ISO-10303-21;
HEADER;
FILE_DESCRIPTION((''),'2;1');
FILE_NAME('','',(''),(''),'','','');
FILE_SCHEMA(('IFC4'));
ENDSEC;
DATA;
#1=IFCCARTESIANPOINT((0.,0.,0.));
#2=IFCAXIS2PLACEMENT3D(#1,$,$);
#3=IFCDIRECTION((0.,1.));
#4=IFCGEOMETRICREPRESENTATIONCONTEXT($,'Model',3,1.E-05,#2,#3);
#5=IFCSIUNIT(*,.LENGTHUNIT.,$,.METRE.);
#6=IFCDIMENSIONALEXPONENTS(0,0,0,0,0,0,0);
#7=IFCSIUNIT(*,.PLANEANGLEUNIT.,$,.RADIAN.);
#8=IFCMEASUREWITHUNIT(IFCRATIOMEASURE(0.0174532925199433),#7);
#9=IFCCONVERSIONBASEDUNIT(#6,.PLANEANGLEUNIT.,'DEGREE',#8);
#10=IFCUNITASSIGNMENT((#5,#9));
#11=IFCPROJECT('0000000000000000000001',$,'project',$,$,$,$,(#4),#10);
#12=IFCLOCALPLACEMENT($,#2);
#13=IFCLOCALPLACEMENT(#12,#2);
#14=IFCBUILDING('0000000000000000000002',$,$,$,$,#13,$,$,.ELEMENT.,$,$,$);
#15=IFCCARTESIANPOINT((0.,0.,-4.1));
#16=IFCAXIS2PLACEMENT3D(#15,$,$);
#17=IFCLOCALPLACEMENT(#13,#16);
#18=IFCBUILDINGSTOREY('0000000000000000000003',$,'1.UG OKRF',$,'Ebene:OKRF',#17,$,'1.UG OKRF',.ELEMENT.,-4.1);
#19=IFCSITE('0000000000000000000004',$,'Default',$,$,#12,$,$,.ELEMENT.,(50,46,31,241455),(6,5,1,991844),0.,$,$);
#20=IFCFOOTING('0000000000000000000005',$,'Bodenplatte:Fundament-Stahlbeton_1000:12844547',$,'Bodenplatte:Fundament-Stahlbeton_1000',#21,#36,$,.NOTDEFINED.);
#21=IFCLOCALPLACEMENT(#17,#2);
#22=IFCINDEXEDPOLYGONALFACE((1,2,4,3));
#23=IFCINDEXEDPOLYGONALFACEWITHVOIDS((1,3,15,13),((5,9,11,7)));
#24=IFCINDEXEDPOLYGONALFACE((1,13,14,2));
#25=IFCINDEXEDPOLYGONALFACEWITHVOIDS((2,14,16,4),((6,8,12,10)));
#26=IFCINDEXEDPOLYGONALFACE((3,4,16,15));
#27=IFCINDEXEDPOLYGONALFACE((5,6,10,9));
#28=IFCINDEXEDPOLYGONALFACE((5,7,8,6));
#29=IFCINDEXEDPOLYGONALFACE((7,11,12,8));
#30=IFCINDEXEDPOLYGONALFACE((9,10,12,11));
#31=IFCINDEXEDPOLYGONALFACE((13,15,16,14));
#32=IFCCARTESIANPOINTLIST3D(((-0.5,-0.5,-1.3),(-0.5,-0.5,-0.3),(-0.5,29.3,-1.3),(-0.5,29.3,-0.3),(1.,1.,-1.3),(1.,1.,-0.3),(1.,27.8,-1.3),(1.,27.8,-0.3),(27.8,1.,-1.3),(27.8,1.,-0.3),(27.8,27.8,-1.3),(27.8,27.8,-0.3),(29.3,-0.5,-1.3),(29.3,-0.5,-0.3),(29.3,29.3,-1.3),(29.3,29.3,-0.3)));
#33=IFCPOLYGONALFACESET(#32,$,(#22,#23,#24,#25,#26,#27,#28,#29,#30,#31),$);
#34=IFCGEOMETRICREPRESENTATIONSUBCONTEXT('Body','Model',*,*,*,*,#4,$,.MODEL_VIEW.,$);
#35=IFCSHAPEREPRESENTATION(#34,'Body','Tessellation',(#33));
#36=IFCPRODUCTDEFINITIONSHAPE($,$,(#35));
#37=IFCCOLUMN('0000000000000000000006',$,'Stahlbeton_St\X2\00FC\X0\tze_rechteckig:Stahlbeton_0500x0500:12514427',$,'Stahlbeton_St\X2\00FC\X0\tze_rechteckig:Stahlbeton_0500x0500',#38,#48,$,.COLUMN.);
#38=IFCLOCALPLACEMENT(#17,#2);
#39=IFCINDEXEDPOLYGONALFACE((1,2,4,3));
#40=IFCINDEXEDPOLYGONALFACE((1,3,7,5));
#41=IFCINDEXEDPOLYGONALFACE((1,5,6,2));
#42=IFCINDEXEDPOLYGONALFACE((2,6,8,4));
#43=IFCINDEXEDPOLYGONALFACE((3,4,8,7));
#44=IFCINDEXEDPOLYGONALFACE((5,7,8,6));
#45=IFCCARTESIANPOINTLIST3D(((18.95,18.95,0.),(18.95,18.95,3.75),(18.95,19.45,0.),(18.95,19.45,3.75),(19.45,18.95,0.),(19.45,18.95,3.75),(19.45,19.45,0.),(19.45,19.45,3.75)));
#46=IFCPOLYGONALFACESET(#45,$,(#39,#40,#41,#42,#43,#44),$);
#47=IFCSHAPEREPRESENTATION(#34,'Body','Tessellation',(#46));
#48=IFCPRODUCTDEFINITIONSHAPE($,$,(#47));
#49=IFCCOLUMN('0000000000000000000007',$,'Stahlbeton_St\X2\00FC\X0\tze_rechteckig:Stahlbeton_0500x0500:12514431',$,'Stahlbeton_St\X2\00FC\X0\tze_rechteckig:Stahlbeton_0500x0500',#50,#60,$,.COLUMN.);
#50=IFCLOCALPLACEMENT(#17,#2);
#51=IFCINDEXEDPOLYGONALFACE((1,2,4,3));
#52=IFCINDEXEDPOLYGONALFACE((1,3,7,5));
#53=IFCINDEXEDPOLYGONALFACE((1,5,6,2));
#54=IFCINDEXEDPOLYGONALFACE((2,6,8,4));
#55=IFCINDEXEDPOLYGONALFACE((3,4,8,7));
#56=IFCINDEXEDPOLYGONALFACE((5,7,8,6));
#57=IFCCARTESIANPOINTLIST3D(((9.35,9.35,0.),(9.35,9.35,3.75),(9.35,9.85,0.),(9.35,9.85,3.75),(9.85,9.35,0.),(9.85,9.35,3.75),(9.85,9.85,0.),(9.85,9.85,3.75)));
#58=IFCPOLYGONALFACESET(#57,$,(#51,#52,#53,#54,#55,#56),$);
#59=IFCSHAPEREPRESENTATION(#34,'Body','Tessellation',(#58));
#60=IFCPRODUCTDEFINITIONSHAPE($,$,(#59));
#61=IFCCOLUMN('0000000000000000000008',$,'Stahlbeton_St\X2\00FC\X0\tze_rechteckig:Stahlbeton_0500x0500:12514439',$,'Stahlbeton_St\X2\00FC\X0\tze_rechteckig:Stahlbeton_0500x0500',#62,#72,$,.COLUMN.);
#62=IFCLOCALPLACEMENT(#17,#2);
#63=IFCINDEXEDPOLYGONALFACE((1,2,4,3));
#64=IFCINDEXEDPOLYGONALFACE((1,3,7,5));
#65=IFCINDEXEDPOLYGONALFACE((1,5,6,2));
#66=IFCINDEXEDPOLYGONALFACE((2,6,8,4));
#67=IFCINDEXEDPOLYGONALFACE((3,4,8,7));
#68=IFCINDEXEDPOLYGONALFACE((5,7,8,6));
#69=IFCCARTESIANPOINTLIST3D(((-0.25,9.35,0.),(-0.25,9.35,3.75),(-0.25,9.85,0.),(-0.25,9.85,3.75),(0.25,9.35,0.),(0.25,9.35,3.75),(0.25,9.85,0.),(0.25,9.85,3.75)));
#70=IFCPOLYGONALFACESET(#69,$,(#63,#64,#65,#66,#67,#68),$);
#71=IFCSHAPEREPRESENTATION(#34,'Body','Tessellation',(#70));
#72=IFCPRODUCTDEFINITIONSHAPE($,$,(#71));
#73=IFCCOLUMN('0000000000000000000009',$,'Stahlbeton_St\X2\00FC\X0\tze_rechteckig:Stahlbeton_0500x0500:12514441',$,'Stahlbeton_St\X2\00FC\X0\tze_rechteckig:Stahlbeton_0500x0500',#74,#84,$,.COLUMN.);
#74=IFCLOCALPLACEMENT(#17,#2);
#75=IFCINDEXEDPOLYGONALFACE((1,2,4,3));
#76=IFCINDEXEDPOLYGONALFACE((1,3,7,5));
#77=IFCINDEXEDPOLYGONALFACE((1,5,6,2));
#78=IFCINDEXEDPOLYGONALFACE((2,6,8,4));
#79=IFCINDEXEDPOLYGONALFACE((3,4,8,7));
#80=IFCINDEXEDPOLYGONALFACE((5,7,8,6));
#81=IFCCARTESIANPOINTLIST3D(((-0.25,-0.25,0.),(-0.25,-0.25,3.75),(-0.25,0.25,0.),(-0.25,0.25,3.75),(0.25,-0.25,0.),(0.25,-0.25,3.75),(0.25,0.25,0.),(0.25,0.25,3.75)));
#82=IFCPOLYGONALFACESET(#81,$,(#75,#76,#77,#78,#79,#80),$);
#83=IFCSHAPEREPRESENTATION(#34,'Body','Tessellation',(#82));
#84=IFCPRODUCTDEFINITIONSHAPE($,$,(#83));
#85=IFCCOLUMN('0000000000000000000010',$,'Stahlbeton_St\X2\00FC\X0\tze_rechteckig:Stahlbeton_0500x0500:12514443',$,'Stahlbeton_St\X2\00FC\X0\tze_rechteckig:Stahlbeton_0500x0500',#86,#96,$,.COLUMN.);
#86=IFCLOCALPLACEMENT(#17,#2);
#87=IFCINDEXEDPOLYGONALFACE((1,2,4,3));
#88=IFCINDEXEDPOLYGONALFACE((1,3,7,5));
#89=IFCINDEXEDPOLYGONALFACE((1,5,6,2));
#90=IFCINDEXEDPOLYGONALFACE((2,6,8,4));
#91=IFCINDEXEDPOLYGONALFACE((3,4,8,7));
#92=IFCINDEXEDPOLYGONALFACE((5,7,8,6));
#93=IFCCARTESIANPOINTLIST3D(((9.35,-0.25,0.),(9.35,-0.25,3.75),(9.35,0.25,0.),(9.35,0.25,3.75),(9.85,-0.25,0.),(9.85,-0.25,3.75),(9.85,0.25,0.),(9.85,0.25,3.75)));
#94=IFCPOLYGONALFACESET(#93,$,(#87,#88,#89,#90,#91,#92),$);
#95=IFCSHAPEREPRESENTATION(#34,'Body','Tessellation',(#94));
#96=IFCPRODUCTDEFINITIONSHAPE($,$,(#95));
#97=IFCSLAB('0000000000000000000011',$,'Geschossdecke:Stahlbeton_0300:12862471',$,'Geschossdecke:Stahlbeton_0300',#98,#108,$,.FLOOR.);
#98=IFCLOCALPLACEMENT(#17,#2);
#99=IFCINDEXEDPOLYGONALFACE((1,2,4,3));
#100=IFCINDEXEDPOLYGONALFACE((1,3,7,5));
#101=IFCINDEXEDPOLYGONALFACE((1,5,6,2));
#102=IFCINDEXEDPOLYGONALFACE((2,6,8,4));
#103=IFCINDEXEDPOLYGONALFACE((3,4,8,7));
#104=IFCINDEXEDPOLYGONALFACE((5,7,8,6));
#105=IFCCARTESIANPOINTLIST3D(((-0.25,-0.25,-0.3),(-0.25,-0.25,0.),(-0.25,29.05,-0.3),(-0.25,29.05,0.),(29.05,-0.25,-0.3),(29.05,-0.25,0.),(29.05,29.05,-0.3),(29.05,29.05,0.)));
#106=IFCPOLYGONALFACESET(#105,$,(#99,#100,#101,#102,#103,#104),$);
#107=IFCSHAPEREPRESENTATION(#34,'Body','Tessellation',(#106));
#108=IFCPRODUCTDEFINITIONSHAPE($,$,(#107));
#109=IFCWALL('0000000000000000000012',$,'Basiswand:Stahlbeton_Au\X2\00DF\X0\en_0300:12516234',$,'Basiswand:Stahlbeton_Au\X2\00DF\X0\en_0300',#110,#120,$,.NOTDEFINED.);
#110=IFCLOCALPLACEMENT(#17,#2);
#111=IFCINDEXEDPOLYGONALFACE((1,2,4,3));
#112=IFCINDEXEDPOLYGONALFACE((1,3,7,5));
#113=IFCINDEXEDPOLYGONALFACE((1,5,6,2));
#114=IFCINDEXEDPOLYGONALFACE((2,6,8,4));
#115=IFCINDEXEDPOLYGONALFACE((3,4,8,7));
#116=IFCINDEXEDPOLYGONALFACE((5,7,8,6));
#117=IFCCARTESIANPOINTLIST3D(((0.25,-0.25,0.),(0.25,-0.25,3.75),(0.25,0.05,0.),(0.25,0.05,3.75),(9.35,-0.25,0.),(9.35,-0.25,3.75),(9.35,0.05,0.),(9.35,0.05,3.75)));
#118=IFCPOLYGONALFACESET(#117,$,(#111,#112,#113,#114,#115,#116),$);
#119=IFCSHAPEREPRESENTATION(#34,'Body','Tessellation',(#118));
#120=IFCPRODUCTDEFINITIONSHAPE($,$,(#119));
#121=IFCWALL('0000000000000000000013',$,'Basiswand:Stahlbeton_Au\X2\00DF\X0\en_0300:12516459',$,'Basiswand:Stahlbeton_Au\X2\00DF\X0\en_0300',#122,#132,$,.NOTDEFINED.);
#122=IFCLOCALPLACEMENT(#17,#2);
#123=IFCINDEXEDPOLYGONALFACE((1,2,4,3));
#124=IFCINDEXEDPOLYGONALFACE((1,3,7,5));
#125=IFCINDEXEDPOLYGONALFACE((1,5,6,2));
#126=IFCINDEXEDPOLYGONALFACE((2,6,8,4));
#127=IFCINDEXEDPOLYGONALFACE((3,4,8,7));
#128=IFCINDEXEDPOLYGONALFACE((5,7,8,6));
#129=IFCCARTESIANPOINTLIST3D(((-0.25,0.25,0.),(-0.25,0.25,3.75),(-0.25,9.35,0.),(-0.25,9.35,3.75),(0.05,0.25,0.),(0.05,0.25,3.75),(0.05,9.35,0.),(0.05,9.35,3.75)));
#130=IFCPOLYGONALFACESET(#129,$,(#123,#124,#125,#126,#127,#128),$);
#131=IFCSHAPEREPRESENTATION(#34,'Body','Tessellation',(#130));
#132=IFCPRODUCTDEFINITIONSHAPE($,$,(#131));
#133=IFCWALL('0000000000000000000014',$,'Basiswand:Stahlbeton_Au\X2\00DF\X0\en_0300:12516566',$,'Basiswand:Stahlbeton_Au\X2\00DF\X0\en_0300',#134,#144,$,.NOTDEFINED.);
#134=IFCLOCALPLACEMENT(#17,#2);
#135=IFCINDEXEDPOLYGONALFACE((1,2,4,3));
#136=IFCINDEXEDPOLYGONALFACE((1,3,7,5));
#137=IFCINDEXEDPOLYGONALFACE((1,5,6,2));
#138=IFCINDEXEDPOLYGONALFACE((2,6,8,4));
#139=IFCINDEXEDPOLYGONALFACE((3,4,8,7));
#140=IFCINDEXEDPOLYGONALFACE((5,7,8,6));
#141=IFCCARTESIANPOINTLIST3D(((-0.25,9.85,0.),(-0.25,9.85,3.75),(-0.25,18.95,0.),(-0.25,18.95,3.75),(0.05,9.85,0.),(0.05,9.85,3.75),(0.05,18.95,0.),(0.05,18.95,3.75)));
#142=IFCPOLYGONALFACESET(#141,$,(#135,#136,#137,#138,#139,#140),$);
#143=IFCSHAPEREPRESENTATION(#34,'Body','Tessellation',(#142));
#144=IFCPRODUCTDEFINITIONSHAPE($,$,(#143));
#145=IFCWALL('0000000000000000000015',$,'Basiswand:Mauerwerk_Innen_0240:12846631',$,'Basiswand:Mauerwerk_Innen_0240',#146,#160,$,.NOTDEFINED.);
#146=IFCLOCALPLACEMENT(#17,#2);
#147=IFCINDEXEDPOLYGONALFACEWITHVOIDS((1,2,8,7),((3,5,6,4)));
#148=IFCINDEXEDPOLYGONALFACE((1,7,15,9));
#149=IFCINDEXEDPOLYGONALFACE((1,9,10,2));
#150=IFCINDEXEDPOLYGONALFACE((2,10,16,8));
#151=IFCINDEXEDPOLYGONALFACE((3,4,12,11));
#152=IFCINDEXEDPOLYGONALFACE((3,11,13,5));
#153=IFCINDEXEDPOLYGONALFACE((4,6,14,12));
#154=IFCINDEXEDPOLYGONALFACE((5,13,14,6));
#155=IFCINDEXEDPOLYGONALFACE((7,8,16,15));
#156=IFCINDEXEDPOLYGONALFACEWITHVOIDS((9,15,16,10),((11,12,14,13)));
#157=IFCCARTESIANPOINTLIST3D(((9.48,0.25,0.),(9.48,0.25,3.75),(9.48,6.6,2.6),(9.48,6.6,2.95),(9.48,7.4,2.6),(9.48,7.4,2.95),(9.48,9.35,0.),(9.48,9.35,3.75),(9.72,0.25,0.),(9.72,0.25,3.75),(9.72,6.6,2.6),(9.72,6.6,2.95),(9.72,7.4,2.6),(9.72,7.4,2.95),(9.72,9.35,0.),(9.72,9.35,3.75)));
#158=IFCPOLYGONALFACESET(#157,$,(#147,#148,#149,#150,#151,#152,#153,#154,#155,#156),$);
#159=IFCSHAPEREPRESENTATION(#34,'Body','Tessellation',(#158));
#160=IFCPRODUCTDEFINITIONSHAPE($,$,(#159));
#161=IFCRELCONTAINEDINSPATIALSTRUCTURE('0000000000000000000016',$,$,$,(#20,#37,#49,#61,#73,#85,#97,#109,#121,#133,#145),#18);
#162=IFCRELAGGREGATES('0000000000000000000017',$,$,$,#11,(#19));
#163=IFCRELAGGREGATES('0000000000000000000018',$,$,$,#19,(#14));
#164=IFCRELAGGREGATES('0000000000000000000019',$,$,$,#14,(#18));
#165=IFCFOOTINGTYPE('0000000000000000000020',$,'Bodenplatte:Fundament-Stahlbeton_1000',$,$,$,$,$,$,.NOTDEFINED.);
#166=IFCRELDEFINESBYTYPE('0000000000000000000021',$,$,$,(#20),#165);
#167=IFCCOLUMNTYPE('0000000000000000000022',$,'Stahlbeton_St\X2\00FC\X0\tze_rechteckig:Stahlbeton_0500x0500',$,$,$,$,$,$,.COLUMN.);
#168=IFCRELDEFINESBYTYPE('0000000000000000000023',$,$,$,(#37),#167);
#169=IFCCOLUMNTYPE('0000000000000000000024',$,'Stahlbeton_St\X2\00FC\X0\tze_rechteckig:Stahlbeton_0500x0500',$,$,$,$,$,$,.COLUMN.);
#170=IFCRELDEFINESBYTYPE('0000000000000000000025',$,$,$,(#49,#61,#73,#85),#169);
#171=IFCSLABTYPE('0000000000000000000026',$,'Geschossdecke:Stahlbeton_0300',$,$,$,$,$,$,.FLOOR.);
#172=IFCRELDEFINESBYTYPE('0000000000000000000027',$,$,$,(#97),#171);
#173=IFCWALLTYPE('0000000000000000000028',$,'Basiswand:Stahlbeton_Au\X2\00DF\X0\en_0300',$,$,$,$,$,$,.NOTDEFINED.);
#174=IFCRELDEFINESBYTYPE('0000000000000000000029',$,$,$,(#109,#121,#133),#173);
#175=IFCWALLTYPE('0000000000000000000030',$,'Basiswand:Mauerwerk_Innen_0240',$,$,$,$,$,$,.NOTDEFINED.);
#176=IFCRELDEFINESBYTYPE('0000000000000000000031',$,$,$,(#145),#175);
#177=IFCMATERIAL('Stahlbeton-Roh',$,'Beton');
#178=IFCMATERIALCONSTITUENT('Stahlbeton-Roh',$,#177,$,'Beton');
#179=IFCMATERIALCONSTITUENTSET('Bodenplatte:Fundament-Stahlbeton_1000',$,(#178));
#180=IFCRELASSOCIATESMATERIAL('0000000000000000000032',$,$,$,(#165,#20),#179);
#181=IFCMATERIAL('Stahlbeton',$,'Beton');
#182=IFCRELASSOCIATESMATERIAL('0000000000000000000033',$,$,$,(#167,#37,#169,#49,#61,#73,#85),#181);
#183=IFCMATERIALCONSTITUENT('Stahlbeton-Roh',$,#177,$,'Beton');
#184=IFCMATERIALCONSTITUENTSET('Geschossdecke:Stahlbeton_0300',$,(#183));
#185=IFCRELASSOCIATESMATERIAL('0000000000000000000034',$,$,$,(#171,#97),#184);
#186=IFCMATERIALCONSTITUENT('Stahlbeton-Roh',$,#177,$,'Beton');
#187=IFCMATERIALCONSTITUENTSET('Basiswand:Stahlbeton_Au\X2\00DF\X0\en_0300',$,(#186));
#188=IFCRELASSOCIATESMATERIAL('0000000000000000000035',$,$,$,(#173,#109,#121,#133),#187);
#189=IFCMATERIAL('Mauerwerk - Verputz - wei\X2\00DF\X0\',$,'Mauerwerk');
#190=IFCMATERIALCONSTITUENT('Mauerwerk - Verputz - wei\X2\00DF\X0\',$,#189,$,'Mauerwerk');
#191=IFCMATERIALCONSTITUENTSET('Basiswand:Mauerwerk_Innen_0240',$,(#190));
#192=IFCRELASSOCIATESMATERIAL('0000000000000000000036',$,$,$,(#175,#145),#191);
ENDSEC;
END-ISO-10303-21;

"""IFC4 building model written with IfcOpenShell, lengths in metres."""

from ifc_helpers import new_model, entity, si_unit, converted_unit, direction, frame, origin, place, context, subcontext, project, spatial, polyline, indexed_curve, outline, extrude, source, transform, mapped, material, constituent, constituent_set, type_object, type_shapes, element, save


model = new_model("IFC4")

# Units and contexts
model_context = context("Model", 3, precision=1e-05, world=origin(), true_north=direction((0.0, 1.0)))
body_context = subcontext(model_context, "Body", "Model", "MODEL_VIEW")
ifc_project = project(units=[si_unit("LENGTHUNIT", "METRE"), converted_unit("PLANEANGLEUNIT", "DEGREE", entity("IfcRatioMeasure", 0.0174532925199433), si_unit("PLANEANGLEUNIT", "RADIAN"), dimensions=[0, 0, 0, 0, 0, 0, 0])], contexts=[model_context])

# Site, building, storey
site_placement = place(None, origin())
site = spatial("IfcSite", under=ifc_project, at=site_placement, Name="Default", CompositionType="ELEMENT", RefLatitude=(50, 46, 31, 241455), RefLongitude=(6, 5, 1, 991844), RefElevation=0.0)
building_placement = place(site_placement, origin())
building = spatial("IfcBuilding", under=site, at=building_placement, CompositionType="ELEMENT")
storey_placement = place(building_placement, frame((0.0, 0.0, -4.1)))
storey = spatial("IfcBuildingStorey", under=building, at=storey_placement, Name="1.UG OKRF", ObjectType="Ebene:OKRF", LongName="1.UG OKRF", CompositionType="ELEMENT", Elevation=-4.1)

# Footing
ifc_material_1 = material(Name="Stahlbeton-Roh", Category="Beton")
ifc_constituent_1 = constituent(ifc_material_1, Name="Stahlbeton-Roh", Category="Beton")
ifc_constituent_set_1 = constituent_set(constituents=[ifc_constituent_1], Name="Bodenplatte:Fundament-Stahlbeton_1000")
footing_type = type_object("IfcFootingType", Name="Bodenplatte:Fundament-Stahlbeton_1000", PredefinedType="NOTDEFINED", material=ifc_constituent_set_1)
footing_placement = place(storey_placement, origin())
element("IfcFooting", 1, at=footing_placement, inside=storey, type_object=footing_type, material=ifc_constituent_set_1, Name="Bodenplatte:Fundament-Stahlbeton_1000:12844547", ObjectType="Bodenplatte:Fundament-Stahlbeton_1000", PredefinedType="NOTDEFINED", context=body_context, shape_type="SweptSolid", body=[
    extrude(outline(polyline([(-14.9, -14.9), (14.9, -14.9), (14.9, 14.9), (-14.9, 14.9), (-14.9, -14.9)]), holes=[polyline([(-13.4, -13.4), (13.4, -13.4), (13.4, 13.4), (-13.4, 13.4), (-13.4, -13.4)])]), frame((14.4, 14.4, -1.3), z_axis=(0.0, 0.0, -1.0), x_axis=(0.0, 1.0, 0.0)), (0.0, 0.0, -1.0), 1.0),
])

# Columns
ifc_material_2 = material(Name="Stahlbeton", Category="Beton")
column_type_1 = type_object("IfcColumnType", Name="Stahlbeton_Stütze_rechteckig:Stahlbeton_0500x0500", PredefinedType="COLUMN", material=ifc_material_2)
shared_shape_1 = source(origin(), body_context, "Body", "SweptSolid", [
    extrude(outline(indexed_curve([(-0.25, -0.25), (0.25, -0.25), (0.25, 0.25), (-0.25, 0.25), (-0.25, -0.25)], self_intersect=False)), frame((19.2, 19.2, -4.1), z_axis=(0.0, 0.0, 1.0), x_axis=(0.0, -1.0, 0.0)), (0.0, 0.0, 1.0), 3.75),
])
type_shapes(column_type_1, [shared_shape_1])
column_placement = place(storey_placement, frame((0.0, 0.0, 4.1)))
element("IfcColumn", 2, at=column_placement, inside=storey, type_object=column_type_1, material=ifc_material_2, Name="Stahlbeton_Stütze_rechteckig:Stahlbeton_0500x0500:12514427", ObjectType="Stahlbeton_Stütze_rechteckig:Stahlbeton_0500x0500", PredefinedType="COLUMN", context=body_context, shape_type="MappedRepresentation", body=[
    mapped(shared_shape_1, transform((0.0, 0.0, 0.0), scale=1.0)),
])
column_type_2 = type_object("IfcColumnType", Name="Stahlbeton_Stütze_rechteckig:Stahlbeton_0500x0500", PredefinedType="COLUMN", material=ifc_material_2)
shared_shape_2 = source(origin(), body_context, "Body", "SweptSolid", [
    extrude(outline(indexed_curve([(-0.25, -0.25), (0.25, -0.25), (0.25, 0.25), (-0.25, 0.25), (-0.25, -0.25)], self_intersect=False)), frame((0.0, 0.0, -4.1), z_axis=(0.0, 0.0, 1.0), x_axis=(0.0, -1.0, 0.0)), (0.0, 0.0, 1.0), 3.75),
])
type_shapes(column_type_2, [shared_shape_2])
for number, where, name in (
    (3, (9.6, 9.6, 4.1), "Stahlbeton_Stütze_rechteckig:Stahlbeton_0500x0500:12514431"),
    (4, (0.0, 9.6, 4.1), "Stahlbeton_Stütze_rechteckig:Stahlbeton_0500x0500:12514439"),
    (5, (0.0, 0.0, 4.1), "Stahlbeton_Stütze_rechteckig:Stahlbeton_0500x0500:12514441"),
    (6, (9.6, 0.0, 4.1), "Stahlbeton_Stütze_rechteckig:Stahlbeton_0500x0500:12514443"),
):
    element("IfcColumn", number, at=place(storey_placement, frame(where)), inside=storey, type_object=column_type_2, material=ifc_material_2, Name=name, ObjectType="Stahlbeton_Stütze_rechteckig:Stahlbeton_0500x0500", PredefinedType="COLUMN", context=body_context, shape_type="MappedRepresentation", body=[
        mapped(shared_shape_2, transform((0.0, 0.0, 0.0), scale=1.0)),
    ])

# Slab
ifc_constituent_2 = constituent(ifc_material_1, Name="Stahlbeton-Roh", Category="Beton")
ifc_constituent_set_2 = constituent_set(constituents=[ifc_constituent_2], Name="Geschossdecke:Stahlbeton_0300")
slab_type = type_object("IfcSlabType", Name="Geschossdecke:Stahlbeton_0300", PredefinedType="FLOOR", material=ifc_constituent_set_2)
slab_placement = place(storey_placement, origin())
element("IfcSlab", 7, at=slab_placement, inside=storey, type_object=slab_type, material=ifc_constituent_set_2, Name="Geschossdecke:Stahlbeton_0300:12862471", ObjectType="Geschossdecke:Stahlbeton_0300", PredefinedType="FLOOR", context=body_context, shape_type="SweptSolid", body=[
    extrude(outline(polyline([(-14.65, -14.65), (14.65, -14.65), (14.65, 14.65), (-14.65, 14.65), (-14.65, -14.65)])), frame((14.4, 14.4, -0.3), z_axis=(0.0, 0.0, -1.0), x_axis=(0.0, -1.0, 0.0)), (0.0, 0.0, -1.0), 0.3),
])

# Walls
ifc_constituent_3 = constituent(ifc_material_1, Name="Stahlbeton-Roh", Category="Beton")
ifc_constituent_set_3 = constituent_set(constituents=[ifc_constituent_3], Name="Basiswand:Stahlbeton_Außen_0300")
wall_type_1 = type_object("IfcWallType", Name="Basiswand:Stahlbeton_Außen_0300", PredefinedType="NOTDEFINED", material=ifc_constituent_set_3)
wall_1_placement = place(storey_placement, frame((9.35, -0.1, 0.0), z_axis=(0.0, 0.0, 1.0), x_axis=(-1.0, 0.0, 0.0)))
element("IfcWall", 8, at=wall_1_placement, inside=storey, type_object=wall_type_1, material=ifc_constituent_set_3, Name="Basiswand:Stahlbeton_Außen_0300:12516234", ObjectType="Basiswand:Stahlbeton_Außen_0300", PredefinedType="NOTDEFINED", context=body_context, shape_type="SweptSolid", body=[
    extrude(outline(polyline([(-4.55, -0.15), (4.55, -0.15), (4.55, 0.15), (-4.55, 0.15), (-4.55, -0.15)])), frame((4.55, 0.0, 0.0), z_axis=(0.0, 0.0, -1.0), x_axis=(-1.0, 0.0, 0.0)), (0.0, 0.0, -1.0), 3.75),
])
for number, where, z_axis, x_axis, name in (
    (9, (-0.1, 0.25, 0.0), (0.0, 0.0, 1.0), (0.0, 1.0, 0.0), "Basiswand:Stahlbeton_Außen_0300:12516459"),
    (10, (-0.1, 9.85, 0.0), (0.0, 0.0, 1.0), (0.0, 1.0, 0.0), "Basiswand:Stahlbeton_Außen_0300:12516566"),
):
    element("IfcWall", number, at=place(storey_placement, frame(where, z_axis=z_axis, x_axis=x_axis)), inside=storey, type_object=wall_type_1, material=ifc_constituent_set_3, Name=name, ObjectType="Basiswand:Stahlbeton_Außen_0300", PredefinedType="NOTDEFINED", context=body_context, shape_type="SweptSolid", body=[
        extrude(outline(polyline([(-0.15, -4.55), (0.15, -4.55), (0.15, 4.55), (-0.15, 4.55), (-0.15, -4.55)])), frame((4.55, 0.0, 0.0), z_axis=(0.0, 0.0, -1.0), x_axis=(0.0, 1.0, 0.0)), (0.0, 0.0, -1.0), 3.75),
    ])

# Wall, opening
ifc_material_3 = material(Name="Mauerwerk - Verputz - weiß", Category="Mauerwerk")
ifc_constituent_4 = constituent(ifc_material_3, Name="Mauerwerk - Verputz - weiß", Category="Mauerwerk")
ifc_constituent_set_4 = constituent_set(constituents=[ifc_constituent_4], Name="Basiswand:Mauerwerk_Innen_0240")
wall_type_2 = type_object("IfcWallType", Name="Basiswand:Mauerwerk_Innen_0240", PredefinedType="NOTDEFINED", material=ifc_constituent_set_4)
wall_2_placement = place(storey_placement, frame((9.6, 9.35, 0.0), z_axis=(0.0, 0.0, 1.0), x_axis=(0.0, -1.0, 0.0)))
wall_2 = element("IfcWall", 11, at=wall_2_placement, inside=storey, type_object=wall_type_2, material=ifc_constituent_set_4, Name="Basiswand:Mauerwerk_Innen_0240:12846631", ObjectType="Basiswand:Mauerwerk_Innen_0240", PredefinedType="NOTDEFINED", context=body_context, shape_type="SweptSolid", body=[
    extrude(outline(indexed_curve([(-1.875, -4.55), (1.875, -4.55), (1.875, 4.55), (-1.875, 4.55), (-1.875, -4.55)], self_intersect=False), holes=[indexed_curve([(1.075, -2.6), (0.725, -2.6), (0.725, -1.8), (1.075, -1.8), (1.075, -2.6)], self_intersect=False)]), frame((4.55, -0.12, 1.875), z_axis=(0.0, 1.0, 0.0), x_axis=(0.0, 0.0, 1.0)), (0.0, 0.0, 1.0), 0.24),
])
opening_1_placement = place(wall_2_placement, origin())
element("IfcOpeningElement", 12, at=opening_1_placement, cuts=wall_2, ObjectType="Opening", PredefinedType="OPENING", context=body_context, shape_type="SweptSolid", body=[
    extrude(outline(indexed_curve([(-0.175, -0.4), (0.175, -0.4), (0.175, 0.4), (-0.175, 0.4), (-0.175, -0.4)], self_intersect=False)), frame((2.35, -0.12, 2.775), z_axis=(0.0, 1.0, 0.0), x_axis=(0.0, 0.0, -1.0)), (0.0, 0.0, 1.0), 0.24),
])

save(model, "model.ifc")
